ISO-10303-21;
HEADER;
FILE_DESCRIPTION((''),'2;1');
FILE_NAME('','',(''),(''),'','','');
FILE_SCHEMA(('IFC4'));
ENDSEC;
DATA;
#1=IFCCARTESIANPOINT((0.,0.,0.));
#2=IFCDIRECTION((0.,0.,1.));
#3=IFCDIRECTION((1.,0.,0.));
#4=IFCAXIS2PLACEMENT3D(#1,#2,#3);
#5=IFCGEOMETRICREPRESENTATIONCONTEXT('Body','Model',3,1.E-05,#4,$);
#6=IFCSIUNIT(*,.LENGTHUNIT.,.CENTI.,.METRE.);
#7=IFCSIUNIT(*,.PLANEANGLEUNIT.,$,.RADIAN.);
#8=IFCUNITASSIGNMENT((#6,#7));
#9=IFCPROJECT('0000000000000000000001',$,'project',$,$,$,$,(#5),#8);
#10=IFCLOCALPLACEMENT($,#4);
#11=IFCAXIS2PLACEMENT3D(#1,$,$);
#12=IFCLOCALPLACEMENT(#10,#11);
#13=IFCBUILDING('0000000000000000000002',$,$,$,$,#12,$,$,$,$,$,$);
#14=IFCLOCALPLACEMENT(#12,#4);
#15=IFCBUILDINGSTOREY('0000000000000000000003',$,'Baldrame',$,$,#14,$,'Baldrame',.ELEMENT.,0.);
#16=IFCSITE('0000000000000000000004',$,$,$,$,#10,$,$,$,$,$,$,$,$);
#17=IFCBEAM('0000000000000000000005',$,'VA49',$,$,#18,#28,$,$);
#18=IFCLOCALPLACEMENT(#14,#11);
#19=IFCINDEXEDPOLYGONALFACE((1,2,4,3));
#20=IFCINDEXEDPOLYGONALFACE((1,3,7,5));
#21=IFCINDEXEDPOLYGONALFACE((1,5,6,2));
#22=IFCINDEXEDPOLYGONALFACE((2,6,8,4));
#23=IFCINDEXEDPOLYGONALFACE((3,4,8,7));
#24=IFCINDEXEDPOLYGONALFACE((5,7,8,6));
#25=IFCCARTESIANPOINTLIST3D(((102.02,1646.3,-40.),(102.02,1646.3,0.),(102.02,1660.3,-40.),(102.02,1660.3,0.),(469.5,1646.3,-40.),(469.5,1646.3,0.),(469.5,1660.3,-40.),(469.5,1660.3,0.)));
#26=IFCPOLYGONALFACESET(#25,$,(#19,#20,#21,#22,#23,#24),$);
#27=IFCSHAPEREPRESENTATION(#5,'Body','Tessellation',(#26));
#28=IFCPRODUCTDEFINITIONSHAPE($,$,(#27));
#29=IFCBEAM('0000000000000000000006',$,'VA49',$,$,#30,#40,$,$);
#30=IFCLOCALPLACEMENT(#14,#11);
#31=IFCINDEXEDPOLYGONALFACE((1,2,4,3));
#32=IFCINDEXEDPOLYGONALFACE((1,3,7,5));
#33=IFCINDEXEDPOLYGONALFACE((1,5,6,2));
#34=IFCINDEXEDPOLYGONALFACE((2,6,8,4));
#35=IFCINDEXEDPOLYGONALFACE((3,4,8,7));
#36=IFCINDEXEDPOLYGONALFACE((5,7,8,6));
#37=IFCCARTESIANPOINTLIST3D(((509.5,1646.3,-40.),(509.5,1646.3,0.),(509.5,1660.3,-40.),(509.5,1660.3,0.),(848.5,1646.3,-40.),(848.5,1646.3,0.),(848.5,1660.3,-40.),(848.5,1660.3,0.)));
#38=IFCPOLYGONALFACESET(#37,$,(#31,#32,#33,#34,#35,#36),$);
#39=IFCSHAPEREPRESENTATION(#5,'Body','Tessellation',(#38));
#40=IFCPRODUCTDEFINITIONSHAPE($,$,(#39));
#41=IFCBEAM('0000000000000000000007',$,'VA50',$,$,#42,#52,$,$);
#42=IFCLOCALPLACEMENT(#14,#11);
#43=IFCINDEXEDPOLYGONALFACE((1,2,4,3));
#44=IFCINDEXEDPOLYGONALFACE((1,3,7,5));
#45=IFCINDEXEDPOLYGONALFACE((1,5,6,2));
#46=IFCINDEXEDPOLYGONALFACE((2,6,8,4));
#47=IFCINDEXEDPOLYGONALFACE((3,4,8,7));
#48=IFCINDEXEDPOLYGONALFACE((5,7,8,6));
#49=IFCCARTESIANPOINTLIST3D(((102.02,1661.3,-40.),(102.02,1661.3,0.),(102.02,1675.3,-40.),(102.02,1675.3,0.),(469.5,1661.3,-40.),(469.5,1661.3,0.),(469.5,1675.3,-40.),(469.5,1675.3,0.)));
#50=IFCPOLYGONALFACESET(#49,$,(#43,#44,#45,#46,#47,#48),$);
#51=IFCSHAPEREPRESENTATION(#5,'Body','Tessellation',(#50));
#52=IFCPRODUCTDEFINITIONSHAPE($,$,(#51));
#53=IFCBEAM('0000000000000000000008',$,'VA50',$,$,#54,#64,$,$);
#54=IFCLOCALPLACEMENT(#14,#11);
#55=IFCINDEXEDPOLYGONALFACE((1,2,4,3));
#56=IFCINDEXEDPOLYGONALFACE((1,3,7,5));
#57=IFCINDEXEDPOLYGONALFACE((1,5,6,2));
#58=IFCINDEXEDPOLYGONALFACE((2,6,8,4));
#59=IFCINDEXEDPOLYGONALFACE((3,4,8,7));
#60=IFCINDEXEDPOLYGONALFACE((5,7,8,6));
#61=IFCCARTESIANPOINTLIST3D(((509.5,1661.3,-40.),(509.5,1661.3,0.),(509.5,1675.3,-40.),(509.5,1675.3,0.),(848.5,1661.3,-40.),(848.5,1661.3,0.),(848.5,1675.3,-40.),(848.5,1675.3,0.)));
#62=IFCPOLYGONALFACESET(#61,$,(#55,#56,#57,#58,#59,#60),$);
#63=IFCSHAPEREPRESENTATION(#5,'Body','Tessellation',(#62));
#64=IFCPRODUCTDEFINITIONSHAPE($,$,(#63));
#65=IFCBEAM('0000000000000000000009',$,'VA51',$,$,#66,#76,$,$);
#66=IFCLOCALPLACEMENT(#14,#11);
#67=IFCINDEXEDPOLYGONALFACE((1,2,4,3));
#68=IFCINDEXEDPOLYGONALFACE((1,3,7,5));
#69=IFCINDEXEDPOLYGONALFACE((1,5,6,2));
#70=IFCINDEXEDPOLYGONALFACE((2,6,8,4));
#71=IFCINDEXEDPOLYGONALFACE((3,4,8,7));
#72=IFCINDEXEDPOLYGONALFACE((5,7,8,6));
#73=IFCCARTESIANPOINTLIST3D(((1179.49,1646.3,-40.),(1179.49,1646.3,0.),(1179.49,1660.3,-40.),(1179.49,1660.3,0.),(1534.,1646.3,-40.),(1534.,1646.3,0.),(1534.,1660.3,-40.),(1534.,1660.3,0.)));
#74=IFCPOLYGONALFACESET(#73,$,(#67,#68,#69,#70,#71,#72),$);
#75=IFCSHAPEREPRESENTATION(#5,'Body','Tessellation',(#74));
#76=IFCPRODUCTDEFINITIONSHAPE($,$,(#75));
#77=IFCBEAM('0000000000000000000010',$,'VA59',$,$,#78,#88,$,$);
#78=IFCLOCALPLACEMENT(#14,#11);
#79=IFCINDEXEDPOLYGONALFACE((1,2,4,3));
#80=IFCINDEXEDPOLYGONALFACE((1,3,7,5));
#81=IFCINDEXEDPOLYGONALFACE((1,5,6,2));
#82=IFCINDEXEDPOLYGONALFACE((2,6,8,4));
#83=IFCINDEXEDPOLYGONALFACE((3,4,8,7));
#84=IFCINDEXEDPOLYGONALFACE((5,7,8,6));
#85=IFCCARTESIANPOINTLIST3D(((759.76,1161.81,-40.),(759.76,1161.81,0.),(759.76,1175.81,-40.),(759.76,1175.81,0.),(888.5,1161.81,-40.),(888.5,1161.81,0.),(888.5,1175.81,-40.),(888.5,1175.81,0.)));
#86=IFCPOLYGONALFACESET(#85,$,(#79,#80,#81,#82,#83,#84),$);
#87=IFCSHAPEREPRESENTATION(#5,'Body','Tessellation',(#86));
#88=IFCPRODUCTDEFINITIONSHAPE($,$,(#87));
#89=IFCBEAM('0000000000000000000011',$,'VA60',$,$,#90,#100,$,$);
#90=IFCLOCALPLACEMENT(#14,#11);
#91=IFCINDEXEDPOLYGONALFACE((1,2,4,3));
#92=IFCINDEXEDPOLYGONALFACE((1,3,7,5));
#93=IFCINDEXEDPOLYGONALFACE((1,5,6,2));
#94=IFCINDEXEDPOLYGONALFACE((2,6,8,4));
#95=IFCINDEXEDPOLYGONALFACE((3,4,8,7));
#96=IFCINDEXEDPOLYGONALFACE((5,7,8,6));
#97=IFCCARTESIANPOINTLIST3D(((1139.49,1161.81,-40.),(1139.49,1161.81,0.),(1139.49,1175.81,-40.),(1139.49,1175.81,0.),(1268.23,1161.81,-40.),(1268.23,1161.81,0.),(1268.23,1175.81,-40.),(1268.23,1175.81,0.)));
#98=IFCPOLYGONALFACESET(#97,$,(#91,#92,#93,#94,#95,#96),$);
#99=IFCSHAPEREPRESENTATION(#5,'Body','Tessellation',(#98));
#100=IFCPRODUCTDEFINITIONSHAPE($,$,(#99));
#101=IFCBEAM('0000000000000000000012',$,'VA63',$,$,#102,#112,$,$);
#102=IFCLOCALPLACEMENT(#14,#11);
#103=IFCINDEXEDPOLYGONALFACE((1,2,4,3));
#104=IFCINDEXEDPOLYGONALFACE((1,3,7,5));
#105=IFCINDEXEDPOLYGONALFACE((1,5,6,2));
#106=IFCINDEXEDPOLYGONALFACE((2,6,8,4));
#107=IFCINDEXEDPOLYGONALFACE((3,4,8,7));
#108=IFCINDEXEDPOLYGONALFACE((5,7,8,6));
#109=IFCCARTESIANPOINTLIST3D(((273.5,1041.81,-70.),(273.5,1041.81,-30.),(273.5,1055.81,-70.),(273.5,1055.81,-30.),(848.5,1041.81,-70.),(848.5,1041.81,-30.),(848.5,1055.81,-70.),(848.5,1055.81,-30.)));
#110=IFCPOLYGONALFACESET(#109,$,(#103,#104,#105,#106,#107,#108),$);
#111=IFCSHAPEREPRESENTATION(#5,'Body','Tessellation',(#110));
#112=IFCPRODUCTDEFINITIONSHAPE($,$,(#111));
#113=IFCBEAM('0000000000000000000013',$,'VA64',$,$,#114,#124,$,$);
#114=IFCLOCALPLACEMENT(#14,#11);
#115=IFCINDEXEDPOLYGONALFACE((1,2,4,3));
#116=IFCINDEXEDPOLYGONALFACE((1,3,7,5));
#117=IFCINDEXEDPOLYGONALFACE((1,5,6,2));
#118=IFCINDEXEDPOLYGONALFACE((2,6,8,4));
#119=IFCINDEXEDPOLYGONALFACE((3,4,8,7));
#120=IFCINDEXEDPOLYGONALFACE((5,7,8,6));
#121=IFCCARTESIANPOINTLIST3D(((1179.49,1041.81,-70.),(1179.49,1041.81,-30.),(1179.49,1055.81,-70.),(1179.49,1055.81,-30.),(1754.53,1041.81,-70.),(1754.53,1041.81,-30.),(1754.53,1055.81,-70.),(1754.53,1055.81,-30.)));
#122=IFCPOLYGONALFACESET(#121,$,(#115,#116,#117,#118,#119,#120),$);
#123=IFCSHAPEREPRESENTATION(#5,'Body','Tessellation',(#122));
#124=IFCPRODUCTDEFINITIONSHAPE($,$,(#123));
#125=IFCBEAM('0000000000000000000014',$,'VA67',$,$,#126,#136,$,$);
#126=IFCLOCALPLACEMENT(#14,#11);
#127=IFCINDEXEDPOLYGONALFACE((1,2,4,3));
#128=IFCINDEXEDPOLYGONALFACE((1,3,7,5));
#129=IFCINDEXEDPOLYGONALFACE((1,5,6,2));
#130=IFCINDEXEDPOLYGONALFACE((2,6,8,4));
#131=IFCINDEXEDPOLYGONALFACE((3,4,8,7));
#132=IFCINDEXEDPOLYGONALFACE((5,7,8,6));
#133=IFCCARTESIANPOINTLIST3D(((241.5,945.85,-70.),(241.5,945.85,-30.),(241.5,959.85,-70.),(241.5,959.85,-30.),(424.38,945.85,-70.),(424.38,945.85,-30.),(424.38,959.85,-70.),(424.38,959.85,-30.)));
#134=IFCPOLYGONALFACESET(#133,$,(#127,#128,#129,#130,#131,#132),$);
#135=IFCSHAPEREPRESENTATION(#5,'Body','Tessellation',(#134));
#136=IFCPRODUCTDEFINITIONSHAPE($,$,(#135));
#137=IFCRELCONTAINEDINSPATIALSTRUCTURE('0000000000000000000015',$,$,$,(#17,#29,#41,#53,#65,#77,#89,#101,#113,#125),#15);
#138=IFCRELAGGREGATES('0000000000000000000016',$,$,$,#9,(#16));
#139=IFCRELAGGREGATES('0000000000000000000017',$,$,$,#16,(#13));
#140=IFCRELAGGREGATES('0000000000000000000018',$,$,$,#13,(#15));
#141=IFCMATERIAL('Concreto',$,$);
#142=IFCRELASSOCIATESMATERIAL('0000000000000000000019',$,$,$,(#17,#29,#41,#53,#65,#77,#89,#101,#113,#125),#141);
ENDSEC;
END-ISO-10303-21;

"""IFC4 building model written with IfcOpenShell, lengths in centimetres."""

from ifc_helpers import new_model, si_unit, frame, origin, origin_with_axes, origin_2d_with_axis, place, context, project, spatial, rectangle, extrude, material, element, save


model = new_model("IFC4")

# Units and contexts
model_context = context("Model", 3, precision=1e-05, world=origin_with_axes(), identifier="Body")
ifc_project = project(units=[si_unit("LENGTHUNIT", "METRE", prefix="CENTI"), si_unit("PLANEANGLEUNIT", "RADIAN")], contexts=[model_context])

# Site, building, storey
site_placement = place(None, origin_with_axes())
site = spatial("IfcSite", under=ifc_project, at=site_placement)
building_placement = place(site_placement, origin())
building = spatial("IfcBuilding", under=site, at=building_placement)
storey_placement = place(building_placement, origin_with_axes())
storey = spatial("IfcBuildingStorey", under=building, at=storey_placement, Name="Baldrame", LongName="Baldrame", CompositionType="ELEMENT", Elevation=0.0)

# Shared definitions
ifc_material = material(Name="Concreto")

# Beams
beam_1_placement = place(storey_placement, frame((285.76, 1653.3, 0.0), z_axis=(0.0, 0.0, 1.0), x_axis=(1.0, 0.0, 0.0)))
element("IfcBeam", 1, at=beam_1_placement, inside=storey, material=ifc_material, Name="VA49", context=model_context, shape_type="SolidModel", body=[
    extrude(rectangle(XDim=14.0, YDim=40.0, at=origin_2d_with_axis()), frame((-183.74, 0.0, -20.0), z_axis=(1.0, 0.0, 0.0), x_axis=(0.0, 1.0, 0.0)), (0.0, 0.0, 1.0), 367.48),
])
beam_2_placement = place(storey_placement, frame((679.0, 1653.3, 0.0), z_axis=(0.0, 0.0, 1.0), x_axis=(1.0, 0.0, 0.0)))
element("IfcBeam", 2, at=beam_2_placement, inside=storey, material=ifc_material, Name="VA49", context=model_context, shape_type="SolidModel", body=[
    extrude(rectangle(XDim=14.0, YDim=40.0, at=origin_2d_with_axis()), frame((-169.5, 0.0, -20.0), z_axis=(1.0, 0.0, 0.0), x_axis=(0.0, 1.0, 0.0)), (0.0, 0.0, 1.0), 339.0),
])
beam_3_placement = place(storey_placement, frame((285.76, 1668.3, 0.0), z_axis=(0.0, 0.0, 1.0), x_axis=(1.0, 0.0, 0.0)))
element("IfcBeam", 3, at=beam_3_placement, inside=storey, material=ifc_material, Name="VA50", context=model_context, shape_type="SolidModel", body=[
    extrude(rectangle(XDim=14.0, YDim=40.0, at=origin_2d_with_axis()), frame((-183.74, 0.0, -20.0), z_axis=(1.0, 0.0, 0.0), x_axis=(0.0, 1.0, 0.0)), (0.0, 0.0, 1.0), 367.48),
])
beam_4_placement = place(storey_placement, frame((679.0, 1668.3, 0.0), z_axis=(0.0, 0.0, 1.0), x_axis=(1.0, 0.0, 0.0)))
element("IfcBeam", 4, at=beam_4_placement, inside=storey, material=ifc_material, Name="VA50", context=model_context, shape_type="SolidModel", body=[
    extrude(rectangle(XDim=14.0, YDim=40.0, at=origin_2d_with_axis()), frame((-169.5, 0.0, -20.0), z_axis=(1.0, 0.0, 0.0), x_axis=(0.0, 1.0, 0.0)), (0.0, 0.0, 1.0), 339.0),
])
beam_5_placement = place(storey_placement, frame((1356.74, 1653.3, 0.0), z_axis=(0.0, 0.0, 1.0), x_axis=(1.0, 0.0, 0.0)))
element("IfcBeam", 5, at=beam_5_placement, inside=storey, material=ifc_material, Name="VA51", context=model_context, shape_type="SolidModel", body=[
    extrude(rectangle(XDim=14.0, YDim=40.0, at=origin_2d_with_axis()), frame((-177.25, 0.0, -20.0), z_axis=(1.0, 0.0, 0.0), x_axis=(0.0, 1.0, 0.0)), (0.0, 0.0, 1.0), 354.51),
])
beam_6_placement = place(storey_placement, frame((824.13, 1168.81, 0.0), z_axis=(0.0, 0.0, 1.0), x_axis=(1.0, 0.0, 0.0)))
element("IfcBeam", 6, at=beam_6_placement, inside=storey, material=ifc_material, Name="VA59", context=model_context, shape_type="SolidModel", body=[
    extrude(rectangle(XDim=14.0, YDim=40.0, at=origin_2d_with_axis()), frame((-64.37, 0.0, -20.0), z_axis=(1.0, 0.0, 0.0), x_axis=(0.0, 1.0, 0.0)), (0.0, 0.0, 1.0), 128.74),
])
beam_7_placement = place(storey_placement, frame((1203.86, 1168.81, 0.0), z_axis=(0.0, 0.0, 1.0), x_axis=(1.0, 0.0, 0.0)))
element("IfcBeam", 7, at=beam_7_placement, inside=storey, material=ifc_material, Name="VA60", context=model_context, shape_type="SolidModel", body=[
    extrude(rectangle(XDim=14.0, YDim=40.0, at=origin_2d_with_axis()), frame((-64.37, 0.0, -20.0), z_axis=(1.0, 0.0, 0.0), x_axis=(0.0, 1.0, 0.0)), (0.0, 0.0, 1.0), 128.74),
])
beam_8_placement = place(storey_placement, frame((561.0, 1048.81, -30.0), z_axis=(0.0, 0.0, 1.0), x_axis=(1.0, 0.0, 0.0)))
element("IfcBeam", 8, at=beam_8_placement, inside=storey, material=ifc_material, Name="VA63", context=model_context, shape_type="SolidModel", body=[
    extrude(rectangle(XDim=14.0, YDim=40.0, at=origin_2d_with_axis()), frame((-287.5, 0.0, -20.0), z_axis=(1.0, 0.0, 0.0), x_axis=(0.0, 1.0, 0.0)), (0.0, 0.0, 1.0), 575.0),
])
beam_9_placement = place(storey_placement, frame((1467.01, 1048.81, -30.0), z_axis=(0.0, 0.0, 1.0), x_axis=(1.0, 0.0, 0.0)))
element("IfcBeam", 9, at=beam_9_placement, inside=storey, material=ifc_material, Name="VA64", context=model_context, shape_type="SolidModel", body=[
    extrude(rectangle(XDim=14.0, YDim=40.0, at=origin_2d_with_axis()), frame((-287.52, 0.0, -20.0), z_axis=(1.0, 0.0, 0.0), x_axis=(0.0, 1.0, 0.0)), (0.0, 0.0, 1.0), 575.04),
])
beam_10_placement = place(storey_placement, frame((332.94, 952.85, -30.0), z_axis=(0.0, 0.0, 1.0), x_axis=(1.0, 0.0, 0.0)))
element("IfcBeam", 10, at=beam_10_placement, inside=storey, material=ifc_material, Name="VA67", context=model_context, shape_type="SolidModel", body=[
    extrude(rectangle(XDim=14.0, YDim=40.0, at=origin_2d_with_axis()), frame((-91.44, 0.0, -20.0), z_axis=(1.0, 0.0, 0.0), x_axis=(0.0, 1.0, 0.0)), (0.0, 0.0, 1.0), 182.88),
])

save(model, "model.ifc")
